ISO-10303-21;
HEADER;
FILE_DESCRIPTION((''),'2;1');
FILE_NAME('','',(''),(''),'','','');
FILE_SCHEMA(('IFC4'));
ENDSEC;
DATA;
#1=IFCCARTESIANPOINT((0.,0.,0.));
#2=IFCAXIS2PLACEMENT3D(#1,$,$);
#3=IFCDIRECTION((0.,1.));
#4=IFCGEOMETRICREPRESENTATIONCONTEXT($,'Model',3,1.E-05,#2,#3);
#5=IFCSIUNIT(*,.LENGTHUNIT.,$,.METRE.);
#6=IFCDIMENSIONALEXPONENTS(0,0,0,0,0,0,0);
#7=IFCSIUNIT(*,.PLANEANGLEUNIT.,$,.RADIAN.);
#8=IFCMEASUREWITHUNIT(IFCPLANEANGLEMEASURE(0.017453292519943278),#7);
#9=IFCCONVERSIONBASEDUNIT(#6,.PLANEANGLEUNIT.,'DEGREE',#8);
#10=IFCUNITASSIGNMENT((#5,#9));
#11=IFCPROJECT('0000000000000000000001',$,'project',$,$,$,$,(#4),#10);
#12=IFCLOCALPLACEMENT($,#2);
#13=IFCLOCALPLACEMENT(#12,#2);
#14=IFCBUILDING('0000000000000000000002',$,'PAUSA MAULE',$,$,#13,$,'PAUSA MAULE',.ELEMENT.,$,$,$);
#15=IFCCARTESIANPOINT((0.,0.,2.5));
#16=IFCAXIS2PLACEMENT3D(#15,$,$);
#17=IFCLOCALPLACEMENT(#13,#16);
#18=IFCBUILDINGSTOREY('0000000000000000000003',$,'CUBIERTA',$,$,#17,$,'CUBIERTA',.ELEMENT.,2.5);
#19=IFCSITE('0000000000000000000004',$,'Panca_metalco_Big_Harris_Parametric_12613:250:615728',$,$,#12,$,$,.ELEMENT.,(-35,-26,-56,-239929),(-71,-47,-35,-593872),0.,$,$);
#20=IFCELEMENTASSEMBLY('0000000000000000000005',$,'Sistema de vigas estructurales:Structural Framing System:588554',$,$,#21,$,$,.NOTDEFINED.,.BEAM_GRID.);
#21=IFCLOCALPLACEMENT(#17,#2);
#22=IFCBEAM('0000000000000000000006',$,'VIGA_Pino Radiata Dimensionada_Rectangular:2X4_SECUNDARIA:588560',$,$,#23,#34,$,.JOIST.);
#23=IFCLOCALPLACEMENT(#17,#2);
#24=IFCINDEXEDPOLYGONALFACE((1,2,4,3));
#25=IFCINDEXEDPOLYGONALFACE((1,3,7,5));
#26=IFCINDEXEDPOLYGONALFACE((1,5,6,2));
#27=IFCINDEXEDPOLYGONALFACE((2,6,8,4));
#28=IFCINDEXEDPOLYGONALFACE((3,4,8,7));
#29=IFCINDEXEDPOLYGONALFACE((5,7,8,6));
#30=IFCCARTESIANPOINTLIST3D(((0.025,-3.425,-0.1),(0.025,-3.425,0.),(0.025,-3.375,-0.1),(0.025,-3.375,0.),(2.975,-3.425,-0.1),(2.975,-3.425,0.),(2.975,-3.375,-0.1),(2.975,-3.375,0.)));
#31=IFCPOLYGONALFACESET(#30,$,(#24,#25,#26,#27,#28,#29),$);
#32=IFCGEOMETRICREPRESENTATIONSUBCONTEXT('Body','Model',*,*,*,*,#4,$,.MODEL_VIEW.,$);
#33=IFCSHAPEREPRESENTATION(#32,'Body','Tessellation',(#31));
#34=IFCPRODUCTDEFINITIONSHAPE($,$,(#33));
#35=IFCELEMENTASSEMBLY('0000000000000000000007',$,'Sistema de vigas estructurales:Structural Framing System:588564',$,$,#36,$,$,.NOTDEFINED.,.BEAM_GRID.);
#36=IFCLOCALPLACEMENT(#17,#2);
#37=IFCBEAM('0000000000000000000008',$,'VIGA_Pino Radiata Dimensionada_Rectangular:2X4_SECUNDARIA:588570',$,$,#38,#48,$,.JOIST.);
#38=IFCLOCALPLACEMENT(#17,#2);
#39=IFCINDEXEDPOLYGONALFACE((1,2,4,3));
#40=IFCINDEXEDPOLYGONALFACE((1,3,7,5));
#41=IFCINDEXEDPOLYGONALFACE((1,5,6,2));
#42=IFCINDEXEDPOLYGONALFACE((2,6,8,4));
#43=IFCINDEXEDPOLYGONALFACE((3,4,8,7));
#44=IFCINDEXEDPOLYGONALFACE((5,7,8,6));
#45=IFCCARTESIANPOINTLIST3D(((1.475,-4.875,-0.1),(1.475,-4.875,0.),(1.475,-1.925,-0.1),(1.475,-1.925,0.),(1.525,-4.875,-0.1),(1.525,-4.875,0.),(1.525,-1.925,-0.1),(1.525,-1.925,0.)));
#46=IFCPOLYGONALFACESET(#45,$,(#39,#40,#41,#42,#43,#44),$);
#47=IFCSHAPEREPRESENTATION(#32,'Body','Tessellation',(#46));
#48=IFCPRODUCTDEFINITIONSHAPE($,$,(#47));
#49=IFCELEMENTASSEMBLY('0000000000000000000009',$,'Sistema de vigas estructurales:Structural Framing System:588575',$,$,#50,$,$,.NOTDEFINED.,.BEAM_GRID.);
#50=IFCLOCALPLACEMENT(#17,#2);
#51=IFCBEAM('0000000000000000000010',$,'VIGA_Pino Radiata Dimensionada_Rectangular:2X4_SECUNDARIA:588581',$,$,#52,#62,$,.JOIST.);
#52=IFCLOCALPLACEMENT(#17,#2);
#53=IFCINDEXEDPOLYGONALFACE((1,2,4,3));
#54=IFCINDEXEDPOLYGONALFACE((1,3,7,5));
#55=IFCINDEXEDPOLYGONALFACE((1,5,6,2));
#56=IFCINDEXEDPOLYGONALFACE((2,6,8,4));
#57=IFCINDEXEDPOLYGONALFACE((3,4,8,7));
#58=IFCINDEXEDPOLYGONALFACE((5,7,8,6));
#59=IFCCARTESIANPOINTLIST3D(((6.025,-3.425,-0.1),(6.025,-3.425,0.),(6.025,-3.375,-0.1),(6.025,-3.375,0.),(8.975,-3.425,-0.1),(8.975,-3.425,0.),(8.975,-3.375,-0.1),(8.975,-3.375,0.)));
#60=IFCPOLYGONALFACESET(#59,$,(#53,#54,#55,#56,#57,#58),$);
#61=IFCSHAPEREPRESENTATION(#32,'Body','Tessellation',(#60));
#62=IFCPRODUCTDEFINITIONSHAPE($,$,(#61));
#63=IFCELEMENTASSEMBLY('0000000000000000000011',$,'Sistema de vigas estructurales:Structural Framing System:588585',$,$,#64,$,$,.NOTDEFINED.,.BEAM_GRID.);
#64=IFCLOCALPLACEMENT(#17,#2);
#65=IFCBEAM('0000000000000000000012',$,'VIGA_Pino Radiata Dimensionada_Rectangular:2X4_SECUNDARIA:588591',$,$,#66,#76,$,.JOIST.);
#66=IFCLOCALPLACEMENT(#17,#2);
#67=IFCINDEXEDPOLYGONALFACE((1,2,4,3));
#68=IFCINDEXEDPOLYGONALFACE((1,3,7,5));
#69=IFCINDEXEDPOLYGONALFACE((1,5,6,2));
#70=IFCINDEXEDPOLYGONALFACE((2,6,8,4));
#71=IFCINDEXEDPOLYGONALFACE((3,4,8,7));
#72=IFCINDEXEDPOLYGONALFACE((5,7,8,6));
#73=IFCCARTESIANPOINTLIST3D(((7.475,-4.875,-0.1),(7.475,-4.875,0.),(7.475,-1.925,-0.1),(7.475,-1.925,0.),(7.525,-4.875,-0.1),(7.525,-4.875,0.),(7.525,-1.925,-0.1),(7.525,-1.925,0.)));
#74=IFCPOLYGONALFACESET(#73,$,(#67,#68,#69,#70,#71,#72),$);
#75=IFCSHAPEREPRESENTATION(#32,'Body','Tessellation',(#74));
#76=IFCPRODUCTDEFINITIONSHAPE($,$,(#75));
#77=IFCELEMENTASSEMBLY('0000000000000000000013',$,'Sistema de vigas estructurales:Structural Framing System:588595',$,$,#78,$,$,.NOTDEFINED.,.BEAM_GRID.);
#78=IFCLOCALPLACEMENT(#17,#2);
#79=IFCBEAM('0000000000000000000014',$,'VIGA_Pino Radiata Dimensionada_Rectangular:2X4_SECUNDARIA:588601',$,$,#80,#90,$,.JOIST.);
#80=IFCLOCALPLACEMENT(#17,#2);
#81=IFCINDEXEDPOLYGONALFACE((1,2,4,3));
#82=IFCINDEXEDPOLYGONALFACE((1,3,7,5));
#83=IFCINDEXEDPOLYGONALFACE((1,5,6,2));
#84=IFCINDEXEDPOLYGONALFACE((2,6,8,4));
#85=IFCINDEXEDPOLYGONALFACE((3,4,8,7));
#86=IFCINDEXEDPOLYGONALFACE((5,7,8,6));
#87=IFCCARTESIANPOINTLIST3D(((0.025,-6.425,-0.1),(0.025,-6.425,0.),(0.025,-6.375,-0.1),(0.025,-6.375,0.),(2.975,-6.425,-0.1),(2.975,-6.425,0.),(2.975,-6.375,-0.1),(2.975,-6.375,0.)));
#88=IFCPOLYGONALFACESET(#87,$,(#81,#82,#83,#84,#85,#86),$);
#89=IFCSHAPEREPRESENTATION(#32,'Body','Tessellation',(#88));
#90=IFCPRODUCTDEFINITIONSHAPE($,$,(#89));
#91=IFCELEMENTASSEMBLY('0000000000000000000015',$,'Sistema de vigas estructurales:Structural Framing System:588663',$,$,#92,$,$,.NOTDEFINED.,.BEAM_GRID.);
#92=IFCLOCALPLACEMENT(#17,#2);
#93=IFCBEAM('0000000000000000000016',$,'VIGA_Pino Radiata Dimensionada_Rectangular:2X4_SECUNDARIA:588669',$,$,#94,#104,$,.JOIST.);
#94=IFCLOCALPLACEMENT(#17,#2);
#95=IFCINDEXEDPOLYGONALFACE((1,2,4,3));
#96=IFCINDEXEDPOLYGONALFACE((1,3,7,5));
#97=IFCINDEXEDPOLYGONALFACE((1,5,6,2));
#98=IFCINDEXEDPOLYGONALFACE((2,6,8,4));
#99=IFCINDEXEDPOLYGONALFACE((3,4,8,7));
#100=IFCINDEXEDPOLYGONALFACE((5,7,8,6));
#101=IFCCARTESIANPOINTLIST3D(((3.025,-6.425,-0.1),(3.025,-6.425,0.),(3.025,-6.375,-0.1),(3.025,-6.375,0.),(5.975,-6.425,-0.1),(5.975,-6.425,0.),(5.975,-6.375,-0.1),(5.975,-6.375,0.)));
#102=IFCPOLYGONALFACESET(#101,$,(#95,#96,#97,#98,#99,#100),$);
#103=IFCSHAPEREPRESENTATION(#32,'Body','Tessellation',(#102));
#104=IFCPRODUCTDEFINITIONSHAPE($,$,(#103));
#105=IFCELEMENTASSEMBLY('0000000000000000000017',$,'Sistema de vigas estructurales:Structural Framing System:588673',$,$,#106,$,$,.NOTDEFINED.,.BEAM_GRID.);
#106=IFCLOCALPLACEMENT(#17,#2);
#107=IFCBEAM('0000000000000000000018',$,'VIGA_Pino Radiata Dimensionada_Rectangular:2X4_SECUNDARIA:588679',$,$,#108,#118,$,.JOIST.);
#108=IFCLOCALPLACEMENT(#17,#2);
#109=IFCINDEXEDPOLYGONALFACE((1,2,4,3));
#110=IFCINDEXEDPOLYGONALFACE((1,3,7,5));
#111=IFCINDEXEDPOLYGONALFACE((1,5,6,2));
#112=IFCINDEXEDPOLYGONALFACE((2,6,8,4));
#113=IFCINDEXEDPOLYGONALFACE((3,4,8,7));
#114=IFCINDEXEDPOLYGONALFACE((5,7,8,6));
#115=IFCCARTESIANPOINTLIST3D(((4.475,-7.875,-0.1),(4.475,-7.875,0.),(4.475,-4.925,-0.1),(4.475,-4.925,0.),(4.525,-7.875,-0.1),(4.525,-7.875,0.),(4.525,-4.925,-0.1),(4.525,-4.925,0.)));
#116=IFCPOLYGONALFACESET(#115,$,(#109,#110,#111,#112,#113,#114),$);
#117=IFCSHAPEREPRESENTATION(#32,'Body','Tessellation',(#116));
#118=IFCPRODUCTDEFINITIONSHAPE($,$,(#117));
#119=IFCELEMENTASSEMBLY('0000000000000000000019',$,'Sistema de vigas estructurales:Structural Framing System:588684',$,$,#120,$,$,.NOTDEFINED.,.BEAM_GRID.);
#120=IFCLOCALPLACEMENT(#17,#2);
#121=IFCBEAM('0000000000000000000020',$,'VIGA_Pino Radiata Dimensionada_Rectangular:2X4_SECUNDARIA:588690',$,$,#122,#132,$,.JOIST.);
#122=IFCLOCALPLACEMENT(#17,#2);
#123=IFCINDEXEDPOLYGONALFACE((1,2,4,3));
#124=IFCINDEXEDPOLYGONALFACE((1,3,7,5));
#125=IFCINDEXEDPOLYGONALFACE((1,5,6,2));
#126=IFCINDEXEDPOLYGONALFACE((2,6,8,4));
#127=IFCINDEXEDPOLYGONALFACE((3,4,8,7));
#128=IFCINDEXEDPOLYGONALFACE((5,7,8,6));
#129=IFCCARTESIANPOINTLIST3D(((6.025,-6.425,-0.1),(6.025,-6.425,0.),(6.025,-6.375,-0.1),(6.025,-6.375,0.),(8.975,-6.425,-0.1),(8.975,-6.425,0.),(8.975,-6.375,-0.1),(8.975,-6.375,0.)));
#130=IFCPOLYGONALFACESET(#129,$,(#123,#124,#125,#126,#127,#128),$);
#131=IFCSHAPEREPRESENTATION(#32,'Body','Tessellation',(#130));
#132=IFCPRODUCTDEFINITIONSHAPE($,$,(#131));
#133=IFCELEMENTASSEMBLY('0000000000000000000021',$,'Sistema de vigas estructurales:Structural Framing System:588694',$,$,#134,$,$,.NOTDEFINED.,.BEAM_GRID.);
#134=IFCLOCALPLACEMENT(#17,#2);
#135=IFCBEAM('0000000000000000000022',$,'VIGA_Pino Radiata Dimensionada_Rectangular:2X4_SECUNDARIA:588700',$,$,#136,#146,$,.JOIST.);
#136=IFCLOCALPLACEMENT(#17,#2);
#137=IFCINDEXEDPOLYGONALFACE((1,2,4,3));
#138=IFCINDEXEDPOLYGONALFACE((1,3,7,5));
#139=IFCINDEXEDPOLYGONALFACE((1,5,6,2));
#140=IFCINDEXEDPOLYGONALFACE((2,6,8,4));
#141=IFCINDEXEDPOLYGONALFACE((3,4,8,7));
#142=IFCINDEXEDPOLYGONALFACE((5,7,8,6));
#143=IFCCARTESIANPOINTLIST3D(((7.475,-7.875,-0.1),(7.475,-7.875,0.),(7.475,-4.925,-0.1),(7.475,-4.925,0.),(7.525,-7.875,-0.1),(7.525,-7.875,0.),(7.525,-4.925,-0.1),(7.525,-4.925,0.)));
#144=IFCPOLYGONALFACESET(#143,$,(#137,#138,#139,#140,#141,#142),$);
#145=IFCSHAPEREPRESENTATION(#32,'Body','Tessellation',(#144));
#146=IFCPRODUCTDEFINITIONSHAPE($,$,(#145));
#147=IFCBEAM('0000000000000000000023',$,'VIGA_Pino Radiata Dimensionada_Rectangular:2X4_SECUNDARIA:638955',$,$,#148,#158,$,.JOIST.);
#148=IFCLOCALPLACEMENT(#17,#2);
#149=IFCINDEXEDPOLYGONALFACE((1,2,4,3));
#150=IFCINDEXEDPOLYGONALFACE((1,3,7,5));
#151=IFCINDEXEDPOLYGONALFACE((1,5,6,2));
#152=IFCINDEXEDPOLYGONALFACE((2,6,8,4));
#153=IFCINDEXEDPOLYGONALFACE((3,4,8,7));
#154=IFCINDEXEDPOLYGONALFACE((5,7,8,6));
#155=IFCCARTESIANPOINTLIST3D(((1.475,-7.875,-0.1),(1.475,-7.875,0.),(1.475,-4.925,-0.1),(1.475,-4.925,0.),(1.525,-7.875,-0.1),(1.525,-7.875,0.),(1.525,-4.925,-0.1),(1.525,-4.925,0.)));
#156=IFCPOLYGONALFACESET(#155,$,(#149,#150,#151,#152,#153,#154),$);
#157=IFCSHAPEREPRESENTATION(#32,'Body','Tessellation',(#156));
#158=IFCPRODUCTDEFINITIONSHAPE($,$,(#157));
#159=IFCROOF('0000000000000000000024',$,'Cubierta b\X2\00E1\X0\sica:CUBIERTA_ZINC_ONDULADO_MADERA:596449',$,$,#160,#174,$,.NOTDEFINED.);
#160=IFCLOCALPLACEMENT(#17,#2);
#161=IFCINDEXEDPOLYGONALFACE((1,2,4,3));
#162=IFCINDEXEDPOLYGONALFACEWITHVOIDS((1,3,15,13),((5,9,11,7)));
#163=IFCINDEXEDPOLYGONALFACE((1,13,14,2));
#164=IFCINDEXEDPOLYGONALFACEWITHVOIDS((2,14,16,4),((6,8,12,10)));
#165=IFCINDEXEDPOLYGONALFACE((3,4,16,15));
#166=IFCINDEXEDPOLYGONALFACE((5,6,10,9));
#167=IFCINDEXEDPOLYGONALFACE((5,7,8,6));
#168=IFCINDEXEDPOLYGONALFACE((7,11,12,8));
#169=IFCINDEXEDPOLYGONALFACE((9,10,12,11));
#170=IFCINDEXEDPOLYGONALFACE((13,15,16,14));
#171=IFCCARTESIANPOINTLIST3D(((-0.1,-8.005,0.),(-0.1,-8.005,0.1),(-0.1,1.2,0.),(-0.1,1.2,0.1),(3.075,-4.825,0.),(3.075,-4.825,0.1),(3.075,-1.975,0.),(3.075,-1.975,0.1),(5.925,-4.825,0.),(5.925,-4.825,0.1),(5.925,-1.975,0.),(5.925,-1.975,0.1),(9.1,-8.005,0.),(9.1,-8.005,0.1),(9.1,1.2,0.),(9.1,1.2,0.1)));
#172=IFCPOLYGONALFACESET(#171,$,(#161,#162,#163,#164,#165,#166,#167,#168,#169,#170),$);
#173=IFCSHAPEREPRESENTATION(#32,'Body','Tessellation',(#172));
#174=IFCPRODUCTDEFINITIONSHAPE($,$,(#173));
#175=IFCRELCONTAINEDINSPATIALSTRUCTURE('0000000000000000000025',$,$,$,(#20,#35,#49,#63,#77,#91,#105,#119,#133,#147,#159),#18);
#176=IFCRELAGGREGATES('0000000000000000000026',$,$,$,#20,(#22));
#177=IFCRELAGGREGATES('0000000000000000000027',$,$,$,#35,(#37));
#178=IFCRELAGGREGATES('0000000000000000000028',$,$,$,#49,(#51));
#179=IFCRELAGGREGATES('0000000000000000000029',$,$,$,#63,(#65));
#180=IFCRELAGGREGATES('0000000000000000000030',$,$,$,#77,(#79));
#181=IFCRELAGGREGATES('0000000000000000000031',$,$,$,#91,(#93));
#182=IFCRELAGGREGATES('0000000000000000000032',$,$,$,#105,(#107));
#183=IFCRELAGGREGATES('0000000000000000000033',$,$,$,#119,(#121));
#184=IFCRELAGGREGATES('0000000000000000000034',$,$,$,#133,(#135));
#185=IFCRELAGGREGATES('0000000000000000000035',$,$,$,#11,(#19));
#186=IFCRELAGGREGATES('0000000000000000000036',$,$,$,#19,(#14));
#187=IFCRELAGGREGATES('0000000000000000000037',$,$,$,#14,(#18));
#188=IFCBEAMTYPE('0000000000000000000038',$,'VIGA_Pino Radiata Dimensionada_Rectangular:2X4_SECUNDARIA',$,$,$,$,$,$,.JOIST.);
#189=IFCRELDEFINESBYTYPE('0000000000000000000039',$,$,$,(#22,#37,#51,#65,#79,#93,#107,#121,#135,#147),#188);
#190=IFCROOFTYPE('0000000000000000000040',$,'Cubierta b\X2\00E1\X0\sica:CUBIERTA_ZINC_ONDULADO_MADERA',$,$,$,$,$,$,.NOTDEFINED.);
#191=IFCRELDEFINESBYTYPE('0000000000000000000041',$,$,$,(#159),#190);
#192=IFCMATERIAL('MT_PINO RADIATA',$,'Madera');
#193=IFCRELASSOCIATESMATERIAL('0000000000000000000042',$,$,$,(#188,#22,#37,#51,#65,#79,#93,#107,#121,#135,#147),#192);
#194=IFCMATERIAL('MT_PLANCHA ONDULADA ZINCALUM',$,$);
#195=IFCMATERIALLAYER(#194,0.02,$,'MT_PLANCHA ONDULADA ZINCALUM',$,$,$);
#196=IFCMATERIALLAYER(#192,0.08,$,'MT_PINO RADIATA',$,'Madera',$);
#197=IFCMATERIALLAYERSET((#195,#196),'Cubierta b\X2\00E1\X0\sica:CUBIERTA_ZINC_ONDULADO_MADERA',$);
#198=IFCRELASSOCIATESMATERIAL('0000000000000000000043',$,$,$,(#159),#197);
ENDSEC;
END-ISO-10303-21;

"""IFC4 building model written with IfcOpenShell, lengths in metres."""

from ifc_helpers import new_model, entity, si_unit, converted_unit, direction, frame, frame_2d, origin, origin_2d_with_axis, place, context, subcontext, project, spatial, rectangle, extrude, source, transform, mapped, material, layer, layer_set, material_profile, profile_set, profile_usage, type_object, type_shapes, element, aggregate, save


model = new_model("IFC4")

# Units and contexts
model_context = context("Model", 3, precision=1e-05, world=origin(), true_north=direction((0.0, 1.0)))
body_context = subcontext(model_context, "Body", "Model", "MODEL_VIEW")
ifc_project = project(units=[si_unit("LENGTHUNIT", "METRE"), converted_unit("PLANEANGLEUNIT", "DEGREE", entity("IfcPlaneAngleMeasure", 0.017453292519943278), si_unit("PLANEANGLEUNIT", "RADIAN"), dimensions=[0, 0, 0, 0, 0, 0, 0])], contexts=[model_context])

# Site, building, storey
site_placement = place(None, origin())
site = spatial("IfcSite", under=ifc_project, at=site_placement, Name="Panca_metalco_Big_Harris_Parametric_12613:250:615728", CompositionType="ELEMENT", RefLatitude=(-35, -26, -56, -239929), RefLongitude=(-71, -47, -35, -593872), RefElevation=0.0)
building_placement = place(site_placement, origin())
building = spatial("IfcBuilding", under=site, at=building_placement, Name="PAUSA MAULE", LongName="PAUSA MAULE", CompositionType="ELEMENT")
storey_placement = place(building_placement, frame((0.0, 0.0, 2.5)))
storey = spatial("IfcBuildingStorey", under=building, at=storey_placement, Name="CUBIERTA", LongName="CUBIERTA", CompositionType="ELEMENT", Elevation=2.5)

# Shared definitions
ifc_material_1 = material(Name="MT_PINO RADIATA", Category="Madera")

# Element assemblies, beams
ifc_material_profile_1 = material_profile(ifc_material_1, rectangle(XDim=2.95, YDim=0.05, at=origin_2d_with_axis()), Name="2X4_SECUNDARIA")
ifc_profile_set_1 = profile_set([ifc_material_profile_1], Name="2X4_SECUNDARIA")
ifc_profile_usage_1 = profile_usage(ifc_profile_set_1, cardinal=8)
beam_type_1 = type_object("IfcBeamType", Name="VIGA_Pino Radiata Dimensionada_Rectangular:2X4_SECUNDARIA", PredefinedType="JOIST", material=ifc_profile_set_1)
shared_shape_1 = source(origin(), body_context, "Body", "SweptSolid", [
    extrude(rectangle(XDim=2.95, YDim=0.05, at=origin_2d_with_axis()), frame((0.0, 0.0, -0.05), z_axis=(0.0, 0.0, 1.0), x_axis=(-1.0, 0.0, 0.0)), (0.0, 0.0, 1.0), 0.1),
])
type_shapes(beam_type_1, [shared_shape_1])
assembly_1_placement = place(storey_placement, origin())
assembly_1 = element("IfcElementAssembly", 1, at=assembly_1_placement, inside=storey, Name="Sistema de vigas estructurales:Structural Framing System:588554", AssemblyPlace="NOTDEFINED", PredefinedType="BEAM_GRID")
beam_1_placement = place(assembly_1_placement, frame((1.5, -3.4, -0.05)))
beam_1 = element("IfcBeam", 2, at=beam_1_placement, type_object=beam_type_1, material=ifc_profile_usage_1, Name="VIGA_Pino Radiata Dimensionada_Rectangular:2X4_SECUNDARIA:588560", PredefinedType="JOIST", context=body_context, shape_type="MappedRepresentation", body=[
    mapped(shared_shape_1, transform((0.0, 0.0, 0.0), scale=1.0)),
])
aggregate(assembly_1, [beam_1])
assembly_2_placement = place(storey_placement, origin())
assembly_2 = element("IfcElementAssembly", 3, at=assembly_2_placement, inside=storey, Name="Sistema de vigas estructurales:Structural Framing System:588564", AssemblyPlace="NOTDEFINED", PredefinedType="BEAM_GRID")
beam_2_placement = place(assembly_2_placement, frame((1.5, -3.4, -0.05), z_axis=(0.0, 0.0, 1.0), x_axis=(0.0, 1.0, 0.0)))
beam_2 = element("IfcBeam", 4, at=beam_2_placement, type_object=beam_type_1, material=ifc_profile_usage_1, Name="VIGA_Pino Radiata Dimensionada_Rectangular:2X4_SECUNDARIA:588570", PredefinedType="JOIST", context=body_context, shape_type="MappedRepresentation", body=[
    mapped(shared_shape_1, transform((0.0, 0.0, 0.0), scale=1.0)),
])
aggregate(assembly_2, [beam_2])
assembly_3_placement = place(storey_placement, origin())
assembly_3 = element("IfcElementAssembly", 5, at=assembly_3_placement, inside=storey, Name="Sistema de vigas estructurales:Structural Framing System:588575", AssemblyPlace="NOTDEFINED", PredefinedType="BEAM_GRID")
beam_3_placement = place(assembly_3_placement, frame((7.5, -3.4, -0.05)))
beam_3 = element("IfcBeam", 6, at=beam_3_placement, type_object=beam_type_1, material=ifc_profile_usage_1, Name="VIGA_Pino Radiata Dimensionada_Rectangular:2X4_SECUNDARIA:588581", PredefinedType="JOIST", context=body_context, shape_type="MappedRepresentation", body=[
    mapped(shared_shape_1, transform((0.0, 0.0, 0.0), scale=1.0)),
])
aggregate(assembly_3, [beam_3])
assembly_4_placement = place(storey_placement, origin())
assembly_4 = element("IfcElementAssembly", 7, at=assembly_4_placement, inside=storey, Name="Sistema de vigas estructurales:Structural Framing System:588585", AssemblyPlace="NOTDEFINED", PredefinedType="BEAM_GRID")
beam_4_placement = place(assembly_4_placement, frame((7.5, -3.4, -0.05), z_axis=(0.0, 0.0, 1.0), x_axis=(0.0, 1.0, 0.0)))
beam_4 = element("IfcBeam", 8, at=beam_4_placement, type_object=beam_type_1, material=ifc_profile_usage_1, Name="VIGA_Pino Radiata Dimensionada_Rectangular:2X4_SECUNDARIA:588591", PredefinedType="JOIST", context=body_context, shape_type="MappedRepresentation", body=[
    mapped(shared_shape_1, transform((0.0, 0.0, 0.0), scale=1.0)),
])
aggregate(assembly_4, [beam_4])
assembly_5_placement = place(storey_placement, origin())
assembly_5 = element("IfcElementAssembly", 9, at=assembly_5_placement, inside=storey, Name="Sistema de vigas estructurales:Structural Framing System:588595", AssemblyPlace="NOTDEFINED", PredefinedType="BEAM_GRID")
beam_5_placement = place(assembly_5_placement, frame((1.5, -6.4, -0.05)))
beam_5 = element("IfcBeam", 10, at=beam_5_placement, type_object=beam_type_1, material=ifc_profile_usage_1, Name="VIGA_Pino Radiata Dimensionada_Rectangular:2X4_SECUNDARIA:588601", PredefinedType="JOIST", context=body_context, shape_type="MappedRepresentation", body=[
    mapped(shared_shape_1, transform((0.0, 0.0, 0.0), scale=1.0)),
])
aggregate(assembly_5, [beam_5])
assembly_6_placement = place(storey_placement, origin())
assembly_6 = element("IfcElementAssembly", 11, at=assembly_6_placement, inside=storey, Name="Sistema de vigas estructurales:Structural Framing System:588663", AssemblyPlace="NOTDEFINED", PredefinedType="BEAM_GRID")
beam_6_placement = place(assembly_6_placement, frame((4.5, -6.4, -0.05)))
beam_6 = element("IfcBeam", 12, at=beam_6_placement, type_object=beam_type_1, material=ifc_profile_usage_1, Name="VIGA_Pino Radiata Dimensionada_Rectangular:2X4_SECUNDARIA:588669", PredefinedType="JOIST", context=body_context, shape_type="MappedRepresentation", body=[
    mapped(shared_shape_1, transform((0.0, 0.0, 0.0), scale=1.0)),
])
aggregate(assembly_6, [beam_6])
assembly_7_placement = place(storey_placement, origin())
assembly_7 = element("IfcElementAssembly", 13, at=assembly_7_placement, inside=storey, Name="Sistema de vigas estructurales:Structural Framing System:588673", AssemblyPlace="NOTDEFINED", PredefinedType="BEAM_GRID")
beam_7_placement = place(assembly_7_placement, frame((4.5, -6.4, -0.05), z_axis=(0.0, 0.0, 1.0), x_axis=(0.0, 1.0, 0.0)))
beam_7 = element("IfcBeam", 14, at=beam_7_placement, type_object=beam_type_1, material=ifc_profile_usage_1, Name="VIGA_Pino Radiata Dimensionada_Rectangular:2X4_SECUNDARIA:588679", PredefinedType="JOIST", context=body_context, shape_type="MappedRepresentation", body=[
    mapped(shared_shape_1, transform((0.0, 0.0, 0.0), scale=1.0)),
])
aggregate(assembly_7, [beam_7])
assembly_8_placement = place(storey_placement, origin())
assembly_8 = element("IfcElementAssembly", 15, at=assembly_8_placement, inside=storey, Name="Sistema de vigas estructurales:Structural Framing System:588684", AssemblyPlace="NOTDEFINED", PredefinedType="BEAM_GRID")
beam_8_placement = place(assembly_8_placement, frame((7.5, -6.4, -0.05)))
beam_8 = element("IfcBeam", 16, at=beam_8_placement, type_object=beam_type_1, material=ifc_profile_usage_1, Name="VIGA_Pino Radiata Dimensionada_Rectangular:2X4_SECUNDARIA:588690", PredefinedType="JOIST", context=body_context, shape_type="MappedRepresentation", body=[
    mapped(shared_shape_1, transform((0.0, 0.0, 0.0), scale=1.0)),
])
aggregate(assembly_8, [beam_8])
assembly_9_placement = place(storey_placement, origin())
assembly_9 = element("IfcElementAssembly", 17, at=assembly_9_placement, inside=storey, Name="Sistema de vigas estructurales:Structural Framing System:588694", AssemblyPlace="NOTDEFINED", PredefinedType="BEAM_GRID")
beam_9_placement = place(assembly_9_placement, frame((7.5, -6.4, -0.05), z_axis=(0.0, 0.0, 1.0), x_axis=(0.0, 1.0, 0.0)))
beam_9 = element("IfcBeam", 18, at=beam_9_placement, type_object=beam_type_1, material=ifc_profile_usage_1, Name="VIGA_Pino Radiata Dimensionada_Rectangular:2X4_SECUNDARIA:588700", PredefinedType="JOIST", context=body_context, shape_type="MappedRepresentation", body=[
    mapped(shared_shape_1, transform((0.0, 0.0, 0.0), scale=1.0)),
])
aggregate(assembly_9, [beam_9])

# Beam
beam_10_placement = place(storey_placement, frame((1.5, -6.4, -0.05), z_axis=(0.0, 0.0, 1.0), x_axis=(0.0, 1.0, 0.0)))
element("IfcBeam", 19, at=beam_10_placement, inside=storey, type_object=beam_type_1, material=ifc_profile_usage_1, Name="VIGA_Pino Radiata Dimensionada_Rectangular:2X4_SECUNDARIA:638955", PredefinedType="JOIST", context=body_context, shape_type="MappedRepresentation", body=[
    mapped(shared_shape_1, transform((0.0, 0.0, 0.0), scale=1.0)),
])

# Roof, opening
ifc_material_2 = material(Name="MT_PLANCHA ONDULADA ZINCALUM")
ifc_layer_1 = layer(ifc_material_2, 0.02, Name="MT_PLANCHA ONDULADA ZINCALUM")
ifc_layer_2 = layer(ifc_material_1, 0.08, Name="MT_PINO RADIATA", Category="Madera")
ifc_layer_set = layer_set([ifc_layer_1, ifc_layer_2], Name="Cubierta básica:CUBIERTA_ZINC_ONDULADO_MADERA")
roof_type = type_object("IfcRoofType", Name="Cubierta básica:CUBIERTA_ZINC_ONDULADO_MADERA", PredefinedType="NOTDEFINED")
roof_placement = place(storey_placement, origin())
roof = element("IfcRoof", 20, at=roof_placement, inside=storey, type_object=roof_type, material=ifc_layer_set, Name="Cubierta básica:CUBIERTA_ZINC_ONDULADO_MADERA:596449", PredefinedType="NOTDEFINED", context=body_context, shape_type="SweptSolid", body=[
    extrude(rectangle(XDim=9.205, YDim=9.2, at=frame_2d((0.0, 0.0), x_axis=(1.0, 0.0))), frame((4.5, -3.4025, 0.0), z_axis=(0.0, 0.0, 1.0), x_axis=(0.0, 1.0, 0.0)), (0.0, 0.0, 1.0), 0.1),
])
opening_placement = place(storey_placement, origin())
element("IfcOpeningElement", 21, at=opening_placement, cuts=roof, PredefinedType="OPENING", context=body_context, shape_type="SweptSolid", body=[
    extrude(rectangle(XDim=2.85, YDim=2.85, at=frame_2d((0.0, 0.0), x_axis=(1.0, 0.0))), frame((4.5, -3.4, 0.0), z_axis=(0.0, 0.0, 1.0), x_axis=(-1.0, 0.0, 0.0)), (0.0, 0.0, 1.0), 0.1),
])

save(model, "model.ifc")
